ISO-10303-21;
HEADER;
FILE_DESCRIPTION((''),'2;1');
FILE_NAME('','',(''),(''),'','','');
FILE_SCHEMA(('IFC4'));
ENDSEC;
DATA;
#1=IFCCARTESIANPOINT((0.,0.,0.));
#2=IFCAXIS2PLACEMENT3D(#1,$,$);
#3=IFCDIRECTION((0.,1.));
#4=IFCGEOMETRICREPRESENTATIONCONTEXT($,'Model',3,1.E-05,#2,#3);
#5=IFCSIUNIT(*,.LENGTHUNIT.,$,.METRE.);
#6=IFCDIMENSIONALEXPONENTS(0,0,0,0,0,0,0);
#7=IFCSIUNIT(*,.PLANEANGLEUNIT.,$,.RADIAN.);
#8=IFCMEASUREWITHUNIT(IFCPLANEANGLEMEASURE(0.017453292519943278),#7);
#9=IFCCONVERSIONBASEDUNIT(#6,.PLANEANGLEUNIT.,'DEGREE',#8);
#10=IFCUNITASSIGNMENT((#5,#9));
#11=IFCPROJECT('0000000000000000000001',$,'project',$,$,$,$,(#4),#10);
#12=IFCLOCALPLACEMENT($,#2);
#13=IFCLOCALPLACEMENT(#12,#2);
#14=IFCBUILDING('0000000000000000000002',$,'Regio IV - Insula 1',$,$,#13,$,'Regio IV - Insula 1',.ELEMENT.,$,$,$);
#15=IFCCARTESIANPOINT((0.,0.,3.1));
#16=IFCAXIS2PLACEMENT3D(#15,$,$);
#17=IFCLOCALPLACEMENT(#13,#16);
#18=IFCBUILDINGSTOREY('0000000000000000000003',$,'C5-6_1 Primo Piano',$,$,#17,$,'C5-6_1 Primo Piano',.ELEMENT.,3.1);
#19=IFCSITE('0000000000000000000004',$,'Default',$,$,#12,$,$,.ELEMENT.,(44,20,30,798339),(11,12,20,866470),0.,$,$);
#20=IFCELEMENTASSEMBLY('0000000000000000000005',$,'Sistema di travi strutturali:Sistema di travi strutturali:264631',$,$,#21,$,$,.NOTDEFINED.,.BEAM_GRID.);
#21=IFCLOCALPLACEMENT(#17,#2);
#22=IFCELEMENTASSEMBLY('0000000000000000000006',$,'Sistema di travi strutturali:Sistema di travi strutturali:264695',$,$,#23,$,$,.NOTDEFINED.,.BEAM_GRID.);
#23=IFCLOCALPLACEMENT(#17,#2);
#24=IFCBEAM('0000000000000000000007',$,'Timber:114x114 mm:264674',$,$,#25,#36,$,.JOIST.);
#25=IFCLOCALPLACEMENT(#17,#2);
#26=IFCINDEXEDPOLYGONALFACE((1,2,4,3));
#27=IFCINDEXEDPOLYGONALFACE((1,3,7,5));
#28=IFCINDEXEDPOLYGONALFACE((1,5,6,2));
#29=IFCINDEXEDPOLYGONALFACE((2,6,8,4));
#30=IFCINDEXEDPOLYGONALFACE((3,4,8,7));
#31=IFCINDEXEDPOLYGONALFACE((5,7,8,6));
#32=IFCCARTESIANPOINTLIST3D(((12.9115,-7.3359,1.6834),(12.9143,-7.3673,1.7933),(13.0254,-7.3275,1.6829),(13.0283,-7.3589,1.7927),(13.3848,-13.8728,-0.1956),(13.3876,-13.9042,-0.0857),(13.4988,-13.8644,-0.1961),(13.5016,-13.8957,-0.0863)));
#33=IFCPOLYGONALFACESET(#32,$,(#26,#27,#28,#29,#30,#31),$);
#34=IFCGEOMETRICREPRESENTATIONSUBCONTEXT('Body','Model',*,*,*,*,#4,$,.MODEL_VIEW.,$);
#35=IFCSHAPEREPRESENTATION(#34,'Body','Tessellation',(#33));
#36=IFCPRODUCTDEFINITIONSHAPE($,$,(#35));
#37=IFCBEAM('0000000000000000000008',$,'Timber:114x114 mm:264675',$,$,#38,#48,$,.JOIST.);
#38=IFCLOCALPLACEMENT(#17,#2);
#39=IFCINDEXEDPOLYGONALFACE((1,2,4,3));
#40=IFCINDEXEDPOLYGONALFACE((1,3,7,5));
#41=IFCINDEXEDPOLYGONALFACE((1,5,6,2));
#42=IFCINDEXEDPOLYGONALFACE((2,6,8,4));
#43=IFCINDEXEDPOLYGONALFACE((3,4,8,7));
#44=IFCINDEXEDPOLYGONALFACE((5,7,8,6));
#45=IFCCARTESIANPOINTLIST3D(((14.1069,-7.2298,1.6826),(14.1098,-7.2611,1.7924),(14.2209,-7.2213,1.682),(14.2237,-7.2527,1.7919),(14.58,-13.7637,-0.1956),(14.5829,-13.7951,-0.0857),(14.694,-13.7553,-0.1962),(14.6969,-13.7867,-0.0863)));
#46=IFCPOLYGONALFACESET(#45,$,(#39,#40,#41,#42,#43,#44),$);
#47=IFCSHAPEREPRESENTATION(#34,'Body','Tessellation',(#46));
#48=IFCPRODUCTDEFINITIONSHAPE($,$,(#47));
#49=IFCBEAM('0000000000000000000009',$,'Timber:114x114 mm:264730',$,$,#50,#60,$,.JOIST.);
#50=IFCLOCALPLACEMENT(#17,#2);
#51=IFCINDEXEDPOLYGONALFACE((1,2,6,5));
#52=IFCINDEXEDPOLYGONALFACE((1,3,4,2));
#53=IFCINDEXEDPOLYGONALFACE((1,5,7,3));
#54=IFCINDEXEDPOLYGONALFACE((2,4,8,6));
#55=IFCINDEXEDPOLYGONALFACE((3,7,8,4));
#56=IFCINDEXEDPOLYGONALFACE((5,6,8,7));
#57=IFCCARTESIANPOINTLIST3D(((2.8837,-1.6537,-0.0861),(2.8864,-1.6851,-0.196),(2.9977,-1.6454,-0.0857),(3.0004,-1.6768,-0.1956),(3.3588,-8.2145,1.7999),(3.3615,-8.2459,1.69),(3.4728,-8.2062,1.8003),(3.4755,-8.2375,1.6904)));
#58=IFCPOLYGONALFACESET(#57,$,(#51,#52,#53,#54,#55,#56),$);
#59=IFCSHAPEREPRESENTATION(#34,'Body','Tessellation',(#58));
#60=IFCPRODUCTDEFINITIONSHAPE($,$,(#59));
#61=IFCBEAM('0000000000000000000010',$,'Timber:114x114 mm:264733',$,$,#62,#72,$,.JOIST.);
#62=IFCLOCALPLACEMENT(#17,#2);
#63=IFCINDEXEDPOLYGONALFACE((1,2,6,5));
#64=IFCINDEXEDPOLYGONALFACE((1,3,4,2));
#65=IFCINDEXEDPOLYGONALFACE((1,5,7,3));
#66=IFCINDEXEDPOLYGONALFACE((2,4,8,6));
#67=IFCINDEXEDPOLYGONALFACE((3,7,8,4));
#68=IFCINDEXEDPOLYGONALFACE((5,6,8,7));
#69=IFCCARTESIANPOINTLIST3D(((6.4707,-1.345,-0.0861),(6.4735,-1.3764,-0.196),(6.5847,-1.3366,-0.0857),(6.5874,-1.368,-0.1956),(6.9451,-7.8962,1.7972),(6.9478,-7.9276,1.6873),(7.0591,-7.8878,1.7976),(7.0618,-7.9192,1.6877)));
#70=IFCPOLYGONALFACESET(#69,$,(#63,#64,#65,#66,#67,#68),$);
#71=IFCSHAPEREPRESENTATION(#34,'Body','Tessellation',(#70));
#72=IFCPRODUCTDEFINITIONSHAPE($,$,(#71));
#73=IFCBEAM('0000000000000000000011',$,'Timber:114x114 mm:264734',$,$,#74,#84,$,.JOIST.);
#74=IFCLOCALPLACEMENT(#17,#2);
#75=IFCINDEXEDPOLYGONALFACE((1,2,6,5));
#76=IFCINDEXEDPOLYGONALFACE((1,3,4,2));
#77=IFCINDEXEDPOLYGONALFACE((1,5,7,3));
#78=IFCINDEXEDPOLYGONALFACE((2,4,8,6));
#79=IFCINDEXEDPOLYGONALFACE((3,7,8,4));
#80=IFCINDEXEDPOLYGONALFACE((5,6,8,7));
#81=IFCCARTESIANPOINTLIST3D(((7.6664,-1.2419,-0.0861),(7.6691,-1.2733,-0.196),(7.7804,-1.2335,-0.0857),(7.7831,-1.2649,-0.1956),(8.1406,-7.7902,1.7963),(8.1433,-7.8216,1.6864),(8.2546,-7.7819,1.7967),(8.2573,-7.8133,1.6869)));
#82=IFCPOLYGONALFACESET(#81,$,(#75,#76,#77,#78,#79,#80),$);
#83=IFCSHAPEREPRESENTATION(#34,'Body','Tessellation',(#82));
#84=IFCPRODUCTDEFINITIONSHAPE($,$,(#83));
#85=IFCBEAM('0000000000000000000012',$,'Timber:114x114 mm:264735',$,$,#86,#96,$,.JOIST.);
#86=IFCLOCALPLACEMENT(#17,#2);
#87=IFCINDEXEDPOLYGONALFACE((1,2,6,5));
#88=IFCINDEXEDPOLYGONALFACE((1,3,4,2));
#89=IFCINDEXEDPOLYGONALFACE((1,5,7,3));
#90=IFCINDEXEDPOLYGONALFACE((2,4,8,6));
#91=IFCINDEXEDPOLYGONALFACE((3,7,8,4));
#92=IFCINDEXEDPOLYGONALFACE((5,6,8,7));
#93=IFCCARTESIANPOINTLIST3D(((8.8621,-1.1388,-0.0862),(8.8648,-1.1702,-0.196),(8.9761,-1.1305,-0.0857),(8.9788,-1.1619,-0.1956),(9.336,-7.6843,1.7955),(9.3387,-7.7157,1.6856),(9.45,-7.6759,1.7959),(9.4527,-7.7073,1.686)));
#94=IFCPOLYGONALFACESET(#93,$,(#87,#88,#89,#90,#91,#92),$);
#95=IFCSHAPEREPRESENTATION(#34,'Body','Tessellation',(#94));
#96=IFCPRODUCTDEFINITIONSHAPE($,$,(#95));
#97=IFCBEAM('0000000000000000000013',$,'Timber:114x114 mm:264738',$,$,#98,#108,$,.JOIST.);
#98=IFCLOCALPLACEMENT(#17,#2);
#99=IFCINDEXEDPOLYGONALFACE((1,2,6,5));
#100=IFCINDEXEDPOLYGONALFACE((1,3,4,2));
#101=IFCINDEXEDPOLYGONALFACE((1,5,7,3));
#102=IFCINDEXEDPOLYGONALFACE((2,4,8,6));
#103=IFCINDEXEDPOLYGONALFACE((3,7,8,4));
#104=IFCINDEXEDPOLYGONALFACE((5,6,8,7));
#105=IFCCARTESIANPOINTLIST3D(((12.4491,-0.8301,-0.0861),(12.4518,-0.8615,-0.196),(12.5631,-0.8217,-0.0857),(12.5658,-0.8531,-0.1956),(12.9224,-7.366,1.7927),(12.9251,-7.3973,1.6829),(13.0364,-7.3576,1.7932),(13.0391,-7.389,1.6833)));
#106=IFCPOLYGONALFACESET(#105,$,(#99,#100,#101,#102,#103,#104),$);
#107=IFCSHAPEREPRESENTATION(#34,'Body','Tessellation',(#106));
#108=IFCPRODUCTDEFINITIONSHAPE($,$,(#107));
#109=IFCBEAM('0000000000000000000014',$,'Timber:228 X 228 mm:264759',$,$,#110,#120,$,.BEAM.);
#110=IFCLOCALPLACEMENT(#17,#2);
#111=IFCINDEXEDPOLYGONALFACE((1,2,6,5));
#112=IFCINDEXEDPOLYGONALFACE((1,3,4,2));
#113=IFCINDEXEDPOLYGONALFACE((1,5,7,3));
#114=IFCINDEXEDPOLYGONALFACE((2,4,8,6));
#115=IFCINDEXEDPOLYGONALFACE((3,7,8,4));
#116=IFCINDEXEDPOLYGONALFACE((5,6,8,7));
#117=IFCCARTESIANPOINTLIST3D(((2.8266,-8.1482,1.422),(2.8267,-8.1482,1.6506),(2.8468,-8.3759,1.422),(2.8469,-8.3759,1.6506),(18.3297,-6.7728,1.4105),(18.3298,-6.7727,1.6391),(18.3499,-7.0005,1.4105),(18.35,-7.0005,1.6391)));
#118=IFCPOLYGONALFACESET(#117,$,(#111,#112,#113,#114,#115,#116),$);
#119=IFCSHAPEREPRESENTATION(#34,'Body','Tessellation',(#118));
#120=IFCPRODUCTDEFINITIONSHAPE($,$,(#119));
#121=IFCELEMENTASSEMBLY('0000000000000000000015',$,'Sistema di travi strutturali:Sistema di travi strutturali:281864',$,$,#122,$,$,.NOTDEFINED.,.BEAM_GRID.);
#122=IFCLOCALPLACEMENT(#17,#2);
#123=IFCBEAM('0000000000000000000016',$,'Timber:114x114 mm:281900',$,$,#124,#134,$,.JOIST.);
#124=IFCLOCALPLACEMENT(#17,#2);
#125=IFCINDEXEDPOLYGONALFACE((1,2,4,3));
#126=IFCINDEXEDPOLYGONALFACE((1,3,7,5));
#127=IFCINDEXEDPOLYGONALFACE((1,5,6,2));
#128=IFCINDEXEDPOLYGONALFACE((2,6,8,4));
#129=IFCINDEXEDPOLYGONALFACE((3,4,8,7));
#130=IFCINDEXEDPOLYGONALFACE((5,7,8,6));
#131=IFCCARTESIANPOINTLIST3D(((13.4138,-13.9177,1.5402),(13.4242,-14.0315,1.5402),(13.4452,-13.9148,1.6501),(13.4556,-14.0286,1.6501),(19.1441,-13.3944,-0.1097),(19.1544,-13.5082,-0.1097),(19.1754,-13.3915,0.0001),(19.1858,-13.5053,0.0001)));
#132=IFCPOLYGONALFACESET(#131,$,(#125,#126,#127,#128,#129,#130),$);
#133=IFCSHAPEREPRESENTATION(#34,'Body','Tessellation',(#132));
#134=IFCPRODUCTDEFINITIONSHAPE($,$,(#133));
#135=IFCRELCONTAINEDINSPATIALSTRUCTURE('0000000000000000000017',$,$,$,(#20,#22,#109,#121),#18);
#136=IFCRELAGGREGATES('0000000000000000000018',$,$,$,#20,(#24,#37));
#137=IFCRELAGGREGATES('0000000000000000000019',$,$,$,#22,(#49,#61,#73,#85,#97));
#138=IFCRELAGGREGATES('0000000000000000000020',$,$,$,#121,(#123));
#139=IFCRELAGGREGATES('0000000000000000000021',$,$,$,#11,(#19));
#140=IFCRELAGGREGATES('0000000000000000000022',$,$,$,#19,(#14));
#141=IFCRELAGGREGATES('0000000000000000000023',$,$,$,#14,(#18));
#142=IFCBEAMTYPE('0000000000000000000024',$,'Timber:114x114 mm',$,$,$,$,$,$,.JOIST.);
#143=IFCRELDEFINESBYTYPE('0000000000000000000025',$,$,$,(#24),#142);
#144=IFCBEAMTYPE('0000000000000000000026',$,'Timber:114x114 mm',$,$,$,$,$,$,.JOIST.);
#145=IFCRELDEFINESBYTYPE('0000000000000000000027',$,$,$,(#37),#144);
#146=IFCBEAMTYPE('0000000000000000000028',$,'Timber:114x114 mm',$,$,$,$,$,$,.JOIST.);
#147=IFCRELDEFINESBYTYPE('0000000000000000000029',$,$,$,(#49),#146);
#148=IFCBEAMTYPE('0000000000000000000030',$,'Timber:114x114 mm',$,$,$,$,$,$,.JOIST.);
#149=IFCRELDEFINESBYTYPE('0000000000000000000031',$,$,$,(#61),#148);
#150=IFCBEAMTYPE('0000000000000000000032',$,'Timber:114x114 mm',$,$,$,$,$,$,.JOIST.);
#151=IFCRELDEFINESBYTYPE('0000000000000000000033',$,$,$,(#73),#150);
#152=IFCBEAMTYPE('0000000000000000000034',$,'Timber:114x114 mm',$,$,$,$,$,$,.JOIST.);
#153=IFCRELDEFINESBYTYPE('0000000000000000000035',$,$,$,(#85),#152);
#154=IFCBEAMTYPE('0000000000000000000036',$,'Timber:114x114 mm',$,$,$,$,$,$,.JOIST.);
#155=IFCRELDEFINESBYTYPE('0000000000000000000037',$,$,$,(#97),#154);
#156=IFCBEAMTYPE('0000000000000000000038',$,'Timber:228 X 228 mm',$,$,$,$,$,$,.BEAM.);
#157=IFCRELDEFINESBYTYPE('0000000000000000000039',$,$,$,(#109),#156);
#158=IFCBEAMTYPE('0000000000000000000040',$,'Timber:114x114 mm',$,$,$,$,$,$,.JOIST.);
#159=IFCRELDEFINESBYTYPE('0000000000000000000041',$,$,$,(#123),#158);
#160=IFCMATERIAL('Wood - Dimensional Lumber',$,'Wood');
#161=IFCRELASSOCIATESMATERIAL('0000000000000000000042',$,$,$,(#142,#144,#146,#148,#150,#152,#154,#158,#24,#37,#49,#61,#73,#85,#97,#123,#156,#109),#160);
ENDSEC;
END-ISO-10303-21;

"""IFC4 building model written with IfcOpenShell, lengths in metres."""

from ifc_helpers import new_model, entity, si_unit, converted_unit, direction, frame, frame_2d, origin, origin_2d_with_axis, place, context, subcontext, project, spatial, rectangle, extrude, source, transform, mapped, material, material_profile, profile_set, profile_usage, type_object, type_shapes, element, aggregate, save


model = new_model("IFC4")

# Units and contexts
model_context = context("Model", 3, precision=1e-05, world=origin(), true_north=direction((0.0, 1.0)))
body_context = subcontext(model_context, "Body", "Model", "MODEL_VIEW")
ifc_project = project(units=[si_unit("LENGTHUNIT", "METRE"), converted_unit("PLANEANGLEUNIT", "DEGREE", entity("IfcPlaneAngleMeasure", 0.017453292519943278), si_unit("PLANEANGLEUNIT", "RADIAN"), dimensions=[0, 0, 0, 0, 0, 0, 0])], contexts=[model_context])

# Site, building, storey
site_placement = place(None, origin())
site = spatial("IfcSite", under=ifc_project, at=site_placement, Name="Default", CompositionType="ELEMENT", RefLatitude=(44, 20, 30, 798339), RefLongitude=(11, 12, 20, 866470), RefElevation=0.0)
building_placement = place(site_placement, origin())
building = spatial("IfcBuilding", under=site, at=building_placement, Name="Regio IV - Insula 1", LongName="Regio IV - Insula 1", CompositionType="ELEMENT")
storey_placement = place(building_placement, frame((0.0, 0.0, 3.1)))
storey = spatial("IfcBuildingStorey", under=building, at=storey_placement, Name="C5-6_1 Primo Piano", LongName="C5-6_1 Primo Piano", CompositionType="ELEMENT", Elevation=3.1)

# Element assembly
assembly_1_placement = place(storey_placement, origin())
assembly_1 = element("IfcElementAssembly", 1, at=assembly_1_placement, inside=storey, Name="Sistema di travi strutturali:Sistema di travi strutturali:264631", AssemblyPlace="NOTDEFINED", PredefinedType="BEAM_GRID")
ifc_material = material(Name="Wood - Dimensional Lumber", Category="Wood")
ifc_material_profile_1 = material_profile(ifc_material, rectangle(XDim=5.294, YDim=0.1143, at=origin_2d_with_axis()), Name="114x114 mm")
ifc_profile_set_1 = profile_set([ifc_material_profile_1], Name="114x114 mm")
ifc_profile_usage_1 = profile_usage(ifc_profile_set_1, cardinal=8)

# Element assembly
assembly_2_placement = place(storey_placement, origin())
assembly_2 = element("IfcElementAssembly", 2, at=assembly_2_placement, inside=storey, Name="Sistema di travi strutturali:Sistema di travi strutturali:264695", AssemblyPlace="NOTDEFINED", PredefinedType="BEAM_GRID")

# Beams
beam_type_1 = type_object("IfcBeamType", Name="Timber:114x114 mm", PredefinedType="JOIST", material=ifc_profile_set_1)
shared_shape_1 = source(origin(), body_context, "Body", "SweptSolid", [
    extrude(rectangle(XDim=6.818, YDim=0.1143, at=origin_2d_with_axis()), frame((0.0, 0.0, -0.0572), z_axis=(0.0, 0.0, 1.0), x_axis=(-1.0, 0.0, 0.0)), (0.0, 0.0, 1.0), 0.1143),
])
type_shapes(beam_type_1, [shared_shape_1])
beam_1_placement = place(assembly_1_placement, frame((13.2065, -10.6158, 0.7986), z_axis=(0.025067, -0.274495, 0.961262), x_axis=(0.069423, -0.958764, -0.275592)))
beam_1 = element("IfcBeam", 3, at=beam_1_placement, type_object=beam_type_1, material=ifc_profile_usage_1, Name="Timber:114x114 mm:264674", PredefinedType="JOIST", context=body_context, shape_type="MappedRepresentation", body=[
    mapped(shared_shape_1, transform((0.0, 0.0, 0.0), scale=1.0)),
])
beam_type_2 = type_object("IfcBeamType", Name="Timber:114x114 mm", PredefinedType="JOIST", material=ifc_profile_set_1)
shared_shape_2 = source(origin(), body_context, "Body", "SweptSolid", [
    extrude(rectangle(XDim=6.815, YDim=0.1143, at=origin_2d_with_axis()), frame((0.0, 0.0, -0.0572), z_axis=(0.0, 0.0, 1.0), x_axis=(-1.0, 0.0, 0.0)), (0.0, 0.0, 1.0), 0.1143),
])
type_shapes(beam_type_2, [shared_shape_2])
beam_2_placement = place(assembly_1_placement, frame((14.4019, -10.5082, 0.7981), z_axis=(0.025067, -0.274495, 0.961262), x_axis=(0.069423, -0.958764, -0.275592)))
beam_2 = element("IfcBeam", 4, at=beam_2_placement, type_object=beam_type_2, material=ifc_profile_usage_1, Name="Timber:114x114 mm:264675", PredefinedType="JOIST", context=body_context, shape_type="MappedRepresentation", body=[
    mapped(shared_shape_2, transform((0.0, 0.0, 0.0), scale=1.0)),
])
aggregate(assembly_1, [beam_1, beam_2])
beam_type_3 = type_object("IfcBeamType", Name="Timber:114x114 mm", PredefinedType="JOIST", material=ifc_profile_set_1)
shared_shape_3 = source(origin(), body_context, "Body", "SweptSolid", [
    extrude(rectangle(XDim=6.843, YDim=0.1143, at=origin_2d_with_axis()), frame((0.0, 0.0, -0.0572), z_axis=(0.0, 0.0, 1.0), x_axis=(-1.0, 0.0, 0.0)), (0.0, 0.0, 1.0), 0.1143),
])
type_shapes(beam_type_3, [shared_shape_3])
beam_3_placement = place(assembly_2_placement, frame((3.1796, -4.9456, 0.8021), z_axis=(-0.02365, 0.274621, 0.961262), x_axis=(0.069423, -0.958758, 0.275614)))
beam_3 = element("IfcBeam", 5, at=beam_3_placement, type_object=beam_type_3, material=ifc_profile_usage_1, Name="Timber:114x114 mm:264730", PredefinedType="JOIST", context=body_context, shape_type="MappedRepresentation", body=[
    mapped(shared_shape_3, transform((0.0, 0.0, 0.0), scale=1.0)),
])
beam_type_4 = type_object("IfcBeamType", Name="Timber:114x114 mm", PredefinedType="JOIST", material=ifc_profile_set_1)
shared_shape_4 = source(origin(), body_context, "Body", "SweptSolid", [
    extrude(rectangle(XDim=6.833, YDim=0.1143, at=origin_2d_with_axis()), frame((0.0, 0.0, -0.0572), z_axis=(0.0, 0.0, 1.0), x_axis=(-1.0, 0.0, 0.0)), (0.0, 0.0, 1.0), 0.1143),
])
type_shapes(beam_type_4, [shared_shape_4])
beam_4_placement = place(assembly_2_placement, frame((6.7663, -4.6321, 0.8008), z_axis=(-0.02365, 0.274621, 0.961262), x_axis=(0.069423, -0.958758, 0.275614)))
beam_4 = element("IfcBeam", 6, at=beam_4_placement, type_object=beam_type_4, material=ifc_profile_usage_1, Name="Timber:114x114 mm:264733", PredefinedType="JOIST", context=body_context, shape_type="MappedRepresentation", body=[
    mapped(shared_shape_4, transform((0.0, 0.0, 0.0), scale=1.0)),
])
beam_type_5 = type_object("IfcBeamType", Name="Timber:114x114 mm", PredefinedType="JOIST", material=ifc_profile_set_1)
shared_shape_5 = source(origin(), body_context, "Body", "SweptSolid", [
    extrude(rectangle(XDim=6.83, YDim=0.1143, at=origin_2d_with_axis()), frame((0.0, 0.0, -0.0572), z_axis=(0.0, 0.0, 1.0), x_axis=(-1.0, 0.0, 0.0)), (0.0, 0.0, 1.0), 0.1143),
])
type_shapes(beam_type_5, [shared_shape_5])
beam_5_placement = place(assembly_2_placement, frame((7.9618, -4.5276, 0.8004), z_axis=(-0.02365, 0.274621, 0.961262), x_axis=(0.069423, -0.958758, 0.275614)))
beam_5 = element("IfcBeam", 7, at=beam_5_placement, type_object=beam_type_5, material=ifc_profile_usage_1, Name="Timber:114x114 mm:264734", PredefinedType="JOIST", context=body_context, shape_type="MappedRepresentation", body=[
    mapped(shared_shape_5, transform((0.0, 0.0, 0.0), scale=1.0)),
])
beam_type_6 = type_object("IfcBeamType", Name="Timber:114x114 mm", PredefinedType="JOIST", material=ifc_profile_set_1)
shared_shape_6 = source(origin(), body_context, "Body", "SweptSolid", [
    extrude(rectangle(XDim=6.827, YDim=0.1143, at=origin_2d_with_axis()), frame((0.0, 0.0, -0.0572), z_axis=(0.0, 0.0, 1.0), x_axis=(-1.0, 0.0, 0.0)), (0.0, 0.0, 1.0), 0.1143),
])
type_shapes(beam_type_6, [shared_shape_6])
beam_6_placement = place(assembly_2_placement, frame((9.1574, -4.4231, 0.7999), z_axis=(-0.02365, 0.274621, 0.961262), x_axis=(0.069423, -0.958758, 0.275614)))
beam_6 = element("IfcBeam", 8, at=beam_6_placement, type_object=beam_type_6, material=ifc_profile_usage_1, Name="Timber:114x114 mm:264735", PredefinedType="JOIST", context=body_context, shape_type="MappedRepresentation", body=[
    mapped(shared_shape_6, transform((0.0, 0.0, 0.0), scale=1.0)),
])
beam_type_7 = type_object("IfcBeamType", Name="Timber:114x114 mm", PredefinedType="JOIST", material=ifc_profile_set_1)
shared_shape_7 = source(origin(), body_context, "Body", "SweptSolid", [
    extrude(rectangle(XDim=6.817, YDim=0.1143, at=origin_2d_with_axis()), frame((0.0, 0.0, -0.0572), z_axis=(0.0, 0.0, 1.0), x_axis=(-1.0, 0.0, 0.0)), (0.0, 0.0, 1.0), 0.1143),
])
type_shapes(beam_type_7, [shared_shape_7])
beam_7_placement = place(assembly_2_placement, frame((12.7441, -4.1095, 0.7986), z_axis=(-0.02365, 0.274621, 0.961262), x_axis=(0.069423, -0.958758, 0.275614)))
beam_7 = element("IfcBeam", 9, at=beam_7_placement, type_object=beam_type_7, material=ifc_profile_usage_1, Name="Timber:114x114 mm:264738", PredefinedType="JOIST", context=body_context, shape_type="MappedRepresentation", body=[
    mapped(shared_shape_7, transform((0.0, 0.0, 0.0), scale=1.0)),
])
aggregate(assembly_2, [beam_3, beam_4, beam_5, beam_6, beam_7])
ifc_material_profile_2 = material_profile(ifc_material, rectangle(XDim=8.091, YDim=0.2286, at=frame_2d((0.0, 0.0), x_axis=(1.0, 0.0))), Name="228 X 228 mm")
ifc_profile_set_2 = profile_set([ifc_material_profile_2], Name="228 X 228 mm")
ifc_profile_usage_2 = profile_usage(ifc_profile_set_2, cardinal=1)
beam_type_8 = type_object("IfcBeamType", Name="Timber:228 X 228 mm", PredefinedType="BEAM", material=ifc_profile_set_2)
shared_shape_8 = source(origin(), body_context, "Body", "SweptSolid", [
    extrude(rectangle(XDim=15.564, YDim=0.2286, at=origin_2d_with_axis()), frame((0.0, 0.0, -0.1143), z_axis=(0.0, 0.0, 1.0), x_axis=(-1.0, 0.0, 0.0)), (0.0, 0.0, 1.0), 0.2286),
])
type_shapes(beam_type_8, [shared_shape_8])
beam_8_placement = place(storey_placement, frame((10.5883, -7.5743, 1.5305), z_axis=(0.000737, 0.000065, 1.0), x_axis=(-0.996087, -0.088371, 0.00074)))
element("IfcBeam", 10, at=beam_8_placement, inside=storey, type_object=beam_type_8, material=ifc_profile_usage_2, Name="Timber:228 X 228 mm:264759", PredefinedType="BEAM", context=body_context, shape_type="MappedRepresentation", body=[
    mapped(shared_shape_8, transform((0.0, 0.0, 0.0), scale=1.0)),
])

# Element assembly, beam
assembly_3_placement = place(storey_placement, origin())
assembly_3 = element("IfcElementAssembly", 11, at=assembly_3_placement, inside=storey, Name="Sistema di travi strutturali:Sistema di travi strutturali:281864", AssemblyPlace="NOTDEFINED", PredefinedType="BEAM_GRID")
beam_type_9 = type_object("IfcBeamType", Name="Timber:114x114 mm", PredefinedType="JOIST", material=ifc_profile_set_1)
shared_shape_9 = source(origin(), body_context, "Body", "SweptSolid", [
    extrude(rectangle(XDim=5.986, YDim=0.1143, at=origin_2d_with_axis()), frame((0.0, 0.0, -0.0572), z_axis=(0.0, 0.0, 1.0), x_axis=(-1.0, 0.0, 0.0)), (0.0, 0.0, 1.0), 0.1143),
])
type_shapes(beam_type_9, [shared_shape_9])
beam_9_placement = place(assembly_3_placement, frame((16.2998, -13.7115, 0.7702), z_axis=(0.274495, 0.025067, 0.961262), x_axis=(-0.957279, -0.087418, 0.275637)))
beam_9 = element("IfcBeam", 12, at=beam_9_placement, type_object=beam_type_9, material=ifc_profile_usage_1, Name="Timber:114x114 mm:281900", PredefinedType="JOIST", context=body_context, shape_type="MappedRepresentation", body=[
    mapped(shared_shape_9, transform((0.0, 0.0, 0.0), scale=1.0)),
])
aggregate(assembly_3, [beam_9])

save(model, "model.ifc")
